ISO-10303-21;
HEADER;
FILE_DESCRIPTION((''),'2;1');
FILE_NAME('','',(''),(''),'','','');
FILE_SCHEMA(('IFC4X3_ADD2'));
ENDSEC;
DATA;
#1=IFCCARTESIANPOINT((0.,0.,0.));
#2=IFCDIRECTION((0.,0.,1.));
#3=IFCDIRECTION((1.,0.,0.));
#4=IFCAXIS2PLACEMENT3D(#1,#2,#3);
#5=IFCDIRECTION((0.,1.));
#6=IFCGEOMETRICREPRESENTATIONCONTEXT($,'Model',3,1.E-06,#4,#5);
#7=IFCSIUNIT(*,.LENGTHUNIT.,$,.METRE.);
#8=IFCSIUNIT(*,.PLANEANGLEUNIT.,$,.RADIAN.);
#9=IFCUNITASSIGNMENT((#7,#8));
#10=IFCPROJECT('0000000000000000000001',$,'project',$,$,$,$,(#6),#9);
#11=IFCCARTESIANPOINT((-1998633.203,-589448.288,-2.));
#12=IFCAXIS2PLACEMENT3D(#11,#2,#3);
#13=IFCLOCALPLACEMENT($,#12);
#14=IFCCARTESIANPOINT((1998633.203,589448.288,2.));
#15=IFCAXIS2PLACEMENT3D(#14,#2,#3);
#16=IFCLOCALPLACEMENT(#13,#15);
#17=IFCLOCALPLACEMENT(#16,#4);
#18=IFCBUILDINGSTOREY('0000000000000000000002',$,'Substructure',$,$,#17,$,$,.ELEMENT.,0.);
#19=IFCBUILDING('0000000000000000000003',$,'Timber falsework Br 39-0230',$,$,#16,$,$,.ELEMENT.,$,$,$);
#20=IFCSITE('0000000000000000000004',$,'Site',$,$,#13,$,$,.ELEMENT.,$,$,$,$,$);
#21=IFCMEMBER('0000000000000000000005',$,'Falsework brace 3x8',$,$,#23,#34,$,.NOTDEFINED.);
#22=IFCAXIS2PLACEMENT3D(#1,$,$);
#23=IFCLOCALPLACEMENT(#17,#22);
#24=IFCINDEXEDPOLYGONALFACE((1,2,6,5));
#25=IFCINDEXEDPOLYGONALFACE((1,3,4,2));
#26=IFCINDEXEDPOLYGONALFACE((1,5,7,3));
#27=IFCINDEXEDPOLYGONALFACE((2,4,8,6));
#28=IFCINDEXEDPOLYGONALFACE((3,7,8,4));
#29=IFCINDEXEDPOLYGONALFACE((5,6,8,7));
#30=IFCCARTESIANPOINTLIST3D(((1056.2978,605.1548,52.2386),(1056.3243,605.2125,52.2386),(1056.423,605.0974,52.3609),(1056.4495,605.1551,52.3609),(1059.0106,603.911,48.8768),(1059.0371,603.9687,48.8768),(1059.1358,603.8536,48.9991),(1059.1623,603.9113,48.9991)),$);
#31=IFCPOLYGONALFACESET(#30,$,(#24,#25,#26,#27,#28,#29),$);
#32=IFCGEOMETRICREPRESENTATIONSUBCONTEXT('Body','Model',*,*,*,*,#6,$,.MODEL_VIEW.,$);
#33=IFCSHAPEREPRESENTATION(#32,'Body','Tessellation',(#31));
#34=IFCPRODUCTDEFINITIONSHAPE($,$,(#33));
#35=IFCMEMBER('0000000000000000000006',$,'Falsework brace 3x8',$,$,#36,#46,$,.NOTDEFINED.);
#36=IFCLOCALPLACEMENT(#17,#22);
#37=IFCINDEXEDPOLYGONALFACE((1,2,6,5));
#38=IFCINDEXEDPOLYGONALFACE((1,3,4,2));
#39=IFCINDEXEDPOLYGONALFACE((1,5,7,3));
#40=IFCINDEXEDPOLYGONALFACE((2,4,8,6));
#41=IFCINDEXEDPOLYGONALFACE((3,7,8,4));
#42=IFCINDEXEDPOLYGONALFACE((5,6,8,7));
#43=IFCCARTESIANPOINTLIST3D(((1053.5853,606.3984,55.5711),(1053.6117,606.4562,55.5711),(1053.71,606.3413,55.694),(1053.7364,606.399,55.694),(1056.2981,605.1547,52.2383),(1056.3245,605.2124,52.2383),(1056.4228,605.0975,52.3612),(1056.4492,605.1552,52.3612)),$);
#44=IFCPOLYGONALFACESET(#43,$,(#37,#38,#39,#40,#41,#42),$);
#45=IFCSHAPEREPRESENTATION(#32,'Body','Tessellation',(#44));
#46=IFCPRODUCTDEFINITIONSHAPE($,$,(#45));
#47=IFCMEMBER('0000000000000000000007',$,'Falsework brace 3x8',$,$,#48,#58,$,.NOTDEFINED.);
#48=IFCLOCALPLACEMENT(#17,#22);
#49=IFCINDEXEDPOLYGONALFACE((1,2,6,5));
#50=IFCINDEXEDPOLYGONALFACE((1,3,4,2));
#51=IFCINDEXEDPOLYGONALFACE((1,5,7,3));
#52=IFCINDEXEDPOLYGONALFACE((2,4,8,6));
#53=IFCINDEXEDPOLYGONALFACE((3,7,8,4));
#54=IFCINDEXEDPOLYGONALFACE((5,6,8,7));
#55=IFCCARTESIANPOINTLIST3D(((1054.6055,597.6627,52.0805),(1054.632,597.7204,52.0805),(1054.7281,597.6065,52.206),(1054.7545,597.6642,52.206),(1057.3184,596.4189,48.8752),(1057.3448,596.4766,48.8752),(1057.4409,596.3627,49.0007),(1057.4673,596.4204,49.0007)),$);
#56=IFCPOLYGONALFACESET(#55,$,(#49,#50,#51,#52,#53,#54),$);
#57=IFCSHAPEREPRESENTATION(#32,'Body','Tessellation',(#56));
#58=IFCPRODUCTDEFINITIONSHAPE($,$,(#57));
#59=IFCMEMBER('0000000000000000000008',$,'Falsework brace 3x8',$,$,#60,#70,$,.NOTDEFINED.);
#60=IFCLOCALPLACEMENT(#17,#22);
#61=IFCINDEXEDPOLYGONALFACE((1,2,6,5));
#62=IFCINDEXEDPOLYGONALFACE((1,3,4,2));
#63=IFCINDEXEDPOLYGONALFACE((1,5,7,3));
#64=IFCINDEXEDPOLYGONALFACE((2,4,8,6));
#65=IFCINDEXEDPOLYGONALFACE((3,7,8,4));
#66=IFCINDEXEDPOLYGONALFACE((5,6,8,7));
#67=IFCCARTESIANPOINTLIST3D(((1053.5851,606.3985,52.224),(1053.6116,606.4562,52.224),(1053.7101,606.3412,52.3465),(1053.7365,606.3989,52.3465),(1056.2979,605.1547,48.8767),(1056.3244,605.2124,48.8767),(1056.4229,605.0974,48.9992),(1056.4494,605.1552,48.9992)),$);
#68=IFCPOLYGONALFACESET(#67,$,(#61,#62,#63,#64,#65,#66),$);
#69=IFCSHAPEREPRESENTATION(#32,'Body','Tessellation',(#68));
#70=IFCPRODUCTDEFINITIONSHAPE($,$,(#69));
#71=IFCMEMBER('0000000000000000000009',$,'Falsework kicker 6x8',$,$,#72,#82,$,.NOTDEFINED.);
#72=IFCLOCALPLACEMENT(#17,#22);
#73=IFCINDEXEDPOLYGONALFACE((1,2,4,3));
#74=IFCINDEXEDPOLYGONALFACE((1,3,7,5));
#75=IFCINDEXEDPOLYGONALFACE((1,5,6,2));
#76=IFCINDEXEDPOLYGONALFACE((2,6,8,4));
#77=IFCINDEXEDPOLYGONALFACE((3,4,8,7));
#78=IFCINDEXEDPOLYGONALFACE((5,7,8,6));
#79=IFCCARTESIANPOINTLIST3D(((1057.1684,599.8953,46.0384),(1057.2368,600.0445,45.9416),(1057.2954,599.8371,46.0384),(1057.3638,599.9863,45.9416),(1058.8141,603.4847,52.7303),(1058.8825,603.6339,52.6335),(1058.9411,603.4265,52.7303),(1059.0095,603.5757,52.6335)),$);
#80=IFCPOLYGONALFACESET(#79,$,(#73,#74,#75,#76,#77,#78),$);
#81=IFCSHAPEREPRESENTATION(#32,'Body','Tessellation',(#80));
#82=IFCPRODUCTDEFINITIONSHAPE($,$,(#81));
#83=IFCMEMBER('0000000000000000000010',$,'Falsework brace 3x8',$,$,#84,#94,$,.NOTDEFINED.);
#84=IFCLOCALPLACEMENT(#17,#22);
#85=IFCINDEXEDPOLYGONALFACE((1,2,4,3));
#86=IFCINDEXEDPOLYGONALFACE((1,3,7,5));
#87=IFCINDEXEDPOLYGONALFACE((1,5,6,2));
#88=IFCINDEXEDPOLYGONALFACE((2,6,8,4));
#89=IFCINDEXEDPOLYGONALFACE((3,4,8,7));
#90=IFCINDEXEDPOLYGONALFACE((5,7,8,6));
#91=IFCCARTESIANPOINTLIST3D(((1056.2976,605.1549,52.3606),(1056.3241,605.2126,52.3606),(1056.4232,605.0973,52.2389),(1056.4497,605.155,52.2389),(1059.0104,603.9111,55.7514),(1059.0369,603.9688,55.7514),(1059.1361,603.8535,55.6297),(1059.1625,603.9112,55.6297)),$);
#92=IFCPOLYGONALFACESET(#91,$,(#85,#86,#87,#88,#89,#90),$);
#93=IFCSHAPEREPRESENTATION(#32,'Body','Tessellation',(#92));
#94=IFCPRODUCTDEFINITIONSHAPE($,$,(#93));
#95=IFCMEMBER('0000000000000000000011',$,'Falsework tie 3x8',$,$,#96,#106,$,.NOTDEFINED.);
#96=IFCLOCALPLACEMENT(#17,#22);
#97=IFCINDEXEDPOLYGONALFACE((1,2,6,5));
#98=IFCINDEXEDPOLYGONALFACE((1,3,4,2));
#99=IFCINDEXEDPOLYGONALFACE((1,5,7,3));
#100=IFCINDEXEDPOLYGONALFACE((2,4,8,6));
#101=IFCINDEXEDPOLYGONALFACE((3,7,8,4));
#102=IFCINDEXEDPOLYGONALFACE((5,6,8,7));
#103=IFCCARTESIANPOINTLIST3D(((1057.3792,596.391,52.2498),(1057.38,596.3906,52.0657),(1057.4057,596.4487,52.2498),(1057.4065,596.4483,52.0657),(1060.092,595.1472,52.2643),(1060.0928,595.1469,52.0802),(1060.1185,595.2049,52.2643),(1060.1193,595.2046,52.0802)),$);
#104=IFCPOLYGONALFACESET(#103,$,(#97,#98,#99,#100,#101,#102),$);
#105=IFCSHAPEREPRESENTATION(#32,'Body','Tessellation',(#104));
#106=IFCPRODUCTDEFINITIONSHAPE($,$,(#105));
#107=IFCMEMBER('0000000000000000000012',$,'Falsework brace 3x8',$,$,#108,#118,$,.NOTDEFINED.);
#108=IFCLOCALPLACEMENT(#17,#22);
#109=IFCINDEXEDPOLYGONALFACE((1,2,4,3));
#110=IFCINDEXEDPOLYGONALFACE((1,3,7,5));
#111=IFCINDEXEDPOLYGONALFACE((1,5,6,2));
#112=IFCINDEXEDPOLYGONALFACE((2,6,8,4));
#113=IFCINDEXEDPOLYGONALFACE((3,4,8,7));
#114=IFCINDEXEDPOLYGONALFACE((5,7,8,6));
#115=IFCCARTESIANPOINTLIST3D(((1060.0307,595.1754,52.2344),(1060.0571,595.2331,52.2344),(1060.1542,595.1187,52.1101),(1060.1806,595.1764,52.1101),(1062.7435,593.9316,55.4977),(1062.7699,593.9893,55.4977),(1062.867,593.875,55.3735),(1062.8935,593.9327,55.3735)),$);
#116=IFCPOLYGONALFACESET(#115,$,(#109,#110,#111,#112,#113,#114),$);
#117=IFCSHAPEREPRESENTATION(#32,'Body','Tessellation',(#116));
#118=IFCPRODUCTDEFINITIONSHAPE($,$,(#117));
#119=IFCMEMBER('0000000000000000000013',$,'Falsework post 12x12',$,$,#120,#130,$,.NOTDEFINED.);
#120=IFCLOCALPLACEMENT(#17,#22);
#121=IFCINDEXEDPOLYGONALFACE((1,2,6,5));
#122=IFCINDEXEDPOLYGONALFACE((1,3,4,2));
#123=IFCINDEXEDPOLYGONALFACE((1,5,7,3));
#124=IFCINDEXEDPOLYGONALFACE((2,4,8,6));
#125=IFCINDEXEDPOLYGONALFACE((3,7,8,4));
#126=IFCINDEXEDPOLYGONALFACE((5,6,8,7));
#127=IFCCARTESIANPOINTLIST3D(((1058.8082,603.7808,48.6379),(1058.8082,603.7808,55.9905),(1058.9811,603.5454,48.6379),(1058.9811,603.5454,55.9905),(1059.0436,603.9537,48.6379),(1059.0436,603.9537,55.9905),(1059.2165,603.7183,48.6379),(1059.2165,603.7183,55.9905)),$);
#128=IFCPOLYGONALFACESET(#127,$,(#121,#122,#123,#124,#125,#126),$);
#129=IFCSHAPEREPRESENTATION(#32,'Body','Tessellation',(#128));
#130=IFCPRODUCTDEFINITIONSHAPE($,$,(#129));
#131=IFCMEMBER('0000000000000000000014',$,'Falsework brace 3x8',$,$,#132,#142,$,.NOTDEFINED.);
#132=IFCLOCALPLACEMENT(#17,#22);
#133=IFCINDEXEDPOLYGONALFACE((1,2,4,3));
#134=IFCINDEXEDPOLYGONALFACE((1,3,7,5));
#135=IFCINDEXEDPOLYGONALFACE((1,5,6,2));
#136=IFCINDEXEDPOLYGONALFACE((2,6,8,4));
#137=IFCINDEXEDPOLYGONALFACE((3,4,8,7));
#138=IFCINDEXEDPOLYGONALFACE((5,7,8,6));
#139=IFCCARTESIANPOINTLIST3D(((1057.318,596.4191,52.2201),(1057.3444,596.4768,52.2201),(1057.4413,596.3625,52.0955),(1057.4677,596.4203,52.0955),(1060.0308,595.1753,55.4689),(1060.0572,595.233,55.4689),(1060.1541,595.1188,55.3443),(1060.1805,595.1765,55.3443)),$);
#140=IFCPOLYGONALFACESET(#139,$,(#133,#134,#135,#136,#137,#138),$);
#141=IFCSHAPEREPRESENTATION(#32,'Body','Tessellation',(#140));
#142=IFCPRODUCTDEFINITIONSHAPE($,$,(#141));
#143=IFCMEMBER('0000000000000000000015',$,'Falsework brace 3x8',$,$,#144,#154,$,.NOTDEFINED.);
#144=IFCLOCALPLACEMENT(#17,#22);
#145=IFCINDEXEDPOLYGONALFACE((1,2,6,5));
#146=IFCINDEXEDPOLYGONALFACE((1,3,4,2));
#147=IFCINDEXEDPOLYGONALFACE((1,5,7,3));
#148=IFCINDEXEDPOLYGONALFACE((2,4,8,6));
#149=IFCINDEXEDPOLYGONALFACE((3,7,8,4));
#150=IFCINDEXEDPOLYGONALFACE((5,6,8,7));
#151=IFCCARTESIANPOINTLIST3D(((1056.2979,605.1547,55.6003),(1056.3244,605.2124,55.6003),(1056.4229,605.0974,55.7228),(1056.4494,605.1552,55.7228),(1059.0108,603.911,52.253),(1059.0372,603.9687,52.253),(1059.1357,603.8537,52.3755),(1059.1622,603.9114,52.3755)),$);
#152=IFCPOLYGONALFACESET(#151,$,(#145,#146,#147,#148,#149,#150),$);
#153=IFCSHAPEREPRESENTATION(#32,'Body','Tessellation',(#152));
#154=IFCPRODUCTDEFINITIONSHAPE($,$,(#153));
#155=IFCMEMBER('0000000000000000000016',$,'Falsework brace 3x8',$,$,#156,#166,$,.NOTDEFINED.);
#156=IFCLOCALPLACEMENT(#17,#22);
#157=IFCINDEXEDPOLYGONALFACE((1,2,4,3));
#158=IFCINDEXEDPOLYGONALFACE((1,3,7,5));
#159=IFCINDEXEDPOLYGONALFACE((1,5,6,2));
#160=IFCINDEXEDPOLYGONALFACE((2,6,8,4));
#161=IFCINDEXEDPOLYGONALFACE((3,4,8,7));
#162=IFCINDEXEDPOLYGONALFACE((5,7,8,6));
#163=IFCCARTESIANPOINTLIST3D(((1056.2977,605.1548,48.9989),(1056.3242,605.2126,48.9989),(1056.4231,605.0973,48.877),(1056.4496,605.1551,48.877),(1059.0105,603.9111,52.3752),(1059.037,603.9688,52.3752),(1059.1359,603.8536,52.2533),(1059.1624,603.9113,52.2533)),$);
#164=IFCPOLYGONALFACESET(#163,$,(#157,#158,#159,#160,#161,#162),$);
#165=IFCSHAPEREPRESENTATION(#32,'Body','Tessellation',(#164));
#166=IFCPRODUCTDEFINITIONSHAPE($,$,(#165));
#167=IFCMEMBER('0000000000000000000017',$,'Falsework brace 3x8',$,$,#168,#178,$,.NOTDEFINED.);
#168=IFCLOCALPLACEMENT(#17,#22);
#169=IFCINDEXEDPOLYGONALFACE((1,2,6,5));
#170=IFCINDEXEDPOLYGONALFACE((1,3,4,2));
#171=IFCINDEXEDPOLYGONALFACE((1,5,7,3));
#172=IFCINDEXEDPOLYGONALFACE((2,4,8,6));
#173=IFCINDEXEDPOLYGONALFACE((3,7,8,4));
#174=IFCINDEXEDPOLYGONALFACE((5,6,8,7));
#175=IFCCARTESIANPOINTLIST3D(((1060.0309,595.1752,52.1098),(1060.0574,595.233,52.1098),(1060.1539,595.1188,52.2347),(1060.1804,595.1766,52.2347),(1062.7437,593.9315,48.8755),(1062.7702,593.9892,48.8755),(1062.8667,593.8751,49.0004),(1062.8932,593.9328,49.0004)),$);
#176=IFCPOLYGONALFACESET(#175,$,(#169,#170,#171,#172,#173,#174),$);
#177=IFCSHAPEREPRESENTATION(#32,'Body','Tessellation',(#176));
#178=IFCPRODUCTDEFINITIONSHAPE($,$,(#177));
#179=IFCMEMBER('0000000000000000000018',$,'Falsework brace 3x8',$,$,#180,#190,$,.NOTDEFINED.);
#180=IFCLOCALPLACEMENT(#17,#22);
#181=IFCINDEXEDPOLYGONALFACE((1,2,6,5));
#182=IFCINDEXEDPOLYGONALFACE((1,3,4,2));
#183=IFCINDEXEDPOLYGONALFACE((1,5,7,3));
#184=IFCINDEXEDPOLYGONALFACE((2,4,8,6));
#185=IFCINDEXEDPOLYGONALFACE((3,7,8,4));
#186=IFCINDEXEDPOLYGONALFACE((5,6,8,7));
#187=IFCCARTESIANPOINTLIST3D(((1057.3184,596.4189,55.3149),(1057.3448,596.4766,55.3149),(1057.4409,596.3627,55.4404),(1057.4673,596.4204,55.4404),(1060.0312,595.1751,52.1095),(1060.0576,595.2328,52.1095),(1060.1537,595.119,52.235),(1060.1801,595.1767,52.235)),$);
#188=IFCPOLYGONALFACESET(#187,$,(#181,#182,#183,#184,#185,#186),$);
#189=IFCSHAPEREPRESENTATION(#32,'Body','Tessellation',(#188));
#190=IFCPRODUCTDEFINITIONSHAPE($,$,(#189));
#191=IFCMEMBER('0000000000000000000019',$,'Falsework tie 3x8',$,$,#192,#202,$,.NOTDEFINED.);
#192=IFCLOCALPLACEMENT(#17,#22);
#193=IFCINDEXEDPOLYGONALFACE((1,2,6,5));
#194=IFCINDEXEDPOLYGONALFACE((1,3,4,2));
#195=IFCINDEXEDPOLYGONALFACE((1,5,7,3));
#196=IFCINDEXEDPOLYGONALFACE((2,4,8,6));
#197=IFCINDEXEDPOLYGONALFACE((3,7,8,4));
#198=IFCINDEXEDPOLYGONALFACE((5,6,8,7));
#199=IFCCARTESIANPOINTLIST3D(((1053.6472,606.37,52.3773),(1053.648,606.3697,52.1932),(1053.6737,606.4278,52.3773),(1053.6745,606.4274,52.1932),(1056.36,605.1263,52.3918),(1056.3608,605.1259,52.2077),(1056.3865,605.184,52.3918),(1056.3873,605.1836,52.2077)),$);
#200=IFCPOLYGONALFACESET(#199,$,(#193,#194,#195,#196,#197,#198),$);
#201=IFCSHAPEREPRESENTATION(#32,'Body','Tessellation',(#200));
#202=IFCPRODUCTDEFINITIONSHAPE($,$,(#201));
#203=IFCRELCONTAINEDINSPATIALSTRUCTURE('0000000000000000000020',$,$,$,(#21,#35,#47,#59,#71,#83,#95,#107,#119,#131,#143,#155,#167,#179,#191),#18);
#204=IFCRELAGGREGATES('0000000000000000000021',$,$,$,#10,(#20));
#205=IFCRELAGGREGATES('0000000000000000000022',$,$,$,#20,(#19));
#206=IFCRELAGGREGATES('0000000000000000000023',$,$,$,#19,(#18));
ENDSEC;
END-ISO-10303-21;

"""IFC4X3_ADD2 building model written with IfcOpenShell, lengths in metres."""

from ifc_helpers import new_model, si_unit, direction, frame, origin, origin_with_axes, origin_2d, place, context, subcontext, project, spatial, rectangle, extrude, element, save


model = new_model("IFC4X3_ADD2")

# Units and contexts
model_context = context("Model", 3, precision=1e-06, world=origin_with_axes(), true_north=direction((0.0, 1.0)))
body_context = subcontext(model_context, "Body", "Model", "MODEL_VIEW")
ifc_project = project(units=[si_unit("LENGTHUNIT", "METRE"), si_unit("PLANEANGLEUNIT", "RADIAN")], contexts=[model_context])

# Site, building, storey
site_placement = place(None, frame((-1998633.203, -589448.288, -2.0), z_axis=(0.0, 0.0, 1.0), x_axis=(1.0, 0.0, 0.0)))
site = spatial("IfcSite", under=ifc_project, at=site_placement, Name="Site", CompositionType="ELEMENT")
building_placement = place(site_placement, frame((1998633.203, 589448.288, 2.0), z_axis=(0.0, 0.0, 1.0), x_axis=(1.0, 0.0, 0.0)))
building = spatial("IfcBuilding", under=site, at=building_placement, Name="Timber falsework Br 39-0230", CompositionType="ELEMENT")
storey_placement = place(building_placement, origin_with_axes())
storey = spatial("IfcBuildingStorey", under=building, at=storey_placement, Name="Substructure", CompositionType="ELEMENT", Elevation=0.0)

# Members
member_1_placement = place(storey_placement, frame((1056.3737, 605.1549, 52.2997), z_axis=(0.603472, -0.27668, -0.747843), x_axis=(0.416765, 0.909014, 0.0)))
element("IfcMember", 1, at=member_1_placement, inside=storey, Name="Falsework brace 3x8", PredefinedType="NOTDEFINED", context=body_context, shape_type="SweptSolid", body=[
    extrude(rectangle(XDim=0.0635, YDim=0.1841, at=origin_2d()), origin(), (0.0, 0.0, 1.0), 4.4953),
])
member_2_placement = place(storey_placement, frame((1053.6608, 606.3987, 55.6325), z_axis=(0.606392, -0.278019, -0.744979), x_axis=(0.416765, 0.909014, 0.0)))
element("IfcMember", 2, at=member_2_placement, inside=storey, Name="Falsework brace 3x8", PredefinedType="NOTDEFINED", context=body_context, shape_type="SweptSolid", body=[
    extrude(rectangle(XDim=0.0635, YDim=0.1841, at=origin_2d()), origin(), (0.0, 0.0, 1.0), 4.4737),
])
member_3_placement = place(storey_placement, frame((1054.68, 597.6634, 52.1433), z_axis=(0.619426, -0.283995, -0.731887), x_axis=(0.416765, 0.909014, 0.0)))
element("IfcMember", 3, at=member_3_placement, inside=storey, Name="Falsework brace 3x8", PredefinedType="NOTDEFINED", context=body_context, shape_type="SweptSolid", body=[
    extrude(rectangle(XDim=0.0635, YDim=0.1841, at=origin_2d()), origin(), (0.0, 0.0, 1.0), 4.3795),
])
member_4_placement = place(storey_placement, frame((1053.6608, 606.3987, 52.2852), z_axis=(0.60493, -0.277349, -0.746416), x_axis=(0.416765, 0.909014, 0.0)))
element("IfcMember", 4, at=member_4_placement, inside=storey, Name="Falsework brace 3x8", PredefinedType="NOTDEFINED", context=body_context, shape_type="SweptSolid", body=[
    extrude(rectangle(XDim=0.0635, YDim=0.1841, at=origin_2d()), origin(), (0.0, 0.0, 1.0), 4.4845),
])
member_5_placement = place(storey_placement, frame((1058.9118, 603.5302, 52.6819), z_axis=(-0.211798, -0.461956, -0.861242), x_axis=(0.909014, -0.416765, 0.0)))
element("IfcMember", 5, at=member_5_placement, inside=storey, Name="Falsework kicker 6x8", PredefinedType="NOTDEFINED", context=body_context, shape_type="SweptSolid", body=[
    extrude(rectangle(XDim=0.1397, YDim=0.1905, at=origin_2d()), origin(), (0.0, 0.0, 1.0), 7.77),
])
member_6_placement = place(storey_placement, frame((1056.3737, 605.1549, 52.2997), z_axis=(0.600569, -0.275349, 0.750666), x_axis=(0.416765, 0.909014, 0.0)))
element("IfcMember", 6, at=member_6_placement, inside=storey, Name="Falsework brace 3x8", PredefinedType="NOTDEFINED", context=body_context, shape_type="SweptSolid", body=[
    extrude(rectangle(XDim=0.0635, YDim=0.1841, at=origin_2d()), origin(), (0.0, 0.0, 1.0), 4.5171),
])
member_7_placement = place(storey_placement, frame((1057.3928, 596.4197, 52.1578), z_axis=(0.909003, -0.41676, 0.004859), x_axis=(0.416765, 0.909014, 0.0)))
element("IfcMember", 7, at=member_7_placement, inside=storey, Name="Falsework tie 3x8", PredefinedType="NOTDEFINED", context=body_context, shape_type="SweptSolid", body=[
    extrude(rectangle(XDim=0.0635, YDim=0.1841, at=origin_2d()), origin(), (0.0, 0.0, 1.0), 2.9844),
])
member_8_placement = place(storey_placement, frame((1060.1057, 595.1759, 52.1723), z_axis=(0.613455, -0.281257, 0.737948), x_axis=(0.416765, 0.909014, 0.0)))
element("IfcMember", 8, at=member_8_placement, inside=storey, Name="Falsework brace 3x8", PredefinedType="NOTDEFINED", context=body_context, shape_type="SweptSolid", body=[
    extrude(rectangle(XDim=0.0635, YDim=0.1841, at=origin_2d()), origin(), (0.0, 0.0, 1.0), 4.4222),
])
member_9_placement = place(storey_placement, frame((1059.0124, 603.7496, 48.6379), z_axis=(0.0, 0.0, 1.0), x_axis=(-0.805928, -0.592013, 0.0)))
element("IfcMember", 9, at=member_9_placement, inside=storey, Name="Falsework post 12x12", PredefinedType="NOTDEFINED", context=body_context, shape_type="SweptSolid", body=[
    extrude(rectangle(XDim=0.2921, YDim=0.2921, at=origin_2d()), origin(), (0.0, 0.0, 1.0), 7.3526),
])
member_10_placement = place(storey_placement, frame((1057.3928, 596.4197, 52.1578), z_axis=(0.614942, -0.281939, 0.736449), x_axis=(0.416765, 0.909014, 0.0)))
element("IfcMember", 10, at=member_10_placement, inside=storey, Name="Falsework brace 3x8", PredefinedType="NOTDEFINED", context=body_context, shape_type="SweptSolid", body=[
    extrude(rectangle(XDim=0.0635, YDim=0.1841, at=origin_2d()), origin(), (0.0, 0.0, 1.0), 4.4115),
])
member_11_placement = place(storey_placement, frame((1056.3737, 605.1549, 55.6615), z_axis=(0.60493, -0.277349, -0.746416), x_axis=(0.416765, 0.909014, 0.0)))
element("IfcMember", 11, at=member_11_placement, inside=storey, Name="Falsework brace 3x8", PredefinedType="NOTDEFINED", context=body_context, shape_type="SweptSolid", body=[
    extrude(rectangle(XDim=0.0635, YDim=0.1841, at=origin_2d()), origin(), (0.0, 0.0, 1.0), 4.4845),
])
member_12_placement = place(storey_placement, frame((1056.3737, 605.1549, 48.9379), z_axis=(0.602019, -0.276014, 0.74926), x_axis=(0.416765, 0.909014, 0.0)))
element("IfcMember", 12, at=member_12_placement, inside=storey, Name="Falsework brace 3x8", PredefinedType="NOTDEFINED", context=body_context, shape_type="SweptSolid", body=[
    extrude(rectangle(XDim=0.0635, YDim=0.1841, at=origin_2d()), origin(), (0.0, 0.0, 1.0), 4.5062),
])
member_13_placement = place(storey_placement, frame((1060.1057, 595.1759, 52.1723), z_axis=(0.616432, -0.282622, -0.734939), x_axis=(0.416765, 0.909014, 0.0)))
element("IfcMember", 13, at=member_13_placement, inside=storey, Name="Falsework brace 3x8", PredefinedType="NOTDEFINED", context=body_context, shape_type="SweptSolid", body=[
    extrude(rectangle(XDim=0.0635, YDim=0.1841, at=origin_2d()), origin(), (0.0, 0.0, 1.0), 4.4008),
])
member_14_placement = place(storey_placement, frame((1057.3928, 596.4197, 55.3776), z_axis=(0.619426, -0.283995, -0.731887), x_axis=(0.416765, 0.909014, 0.0)))
element("IfcMember", 14, at=member_14_placement, inside=storey, Name="Falsework brace 3x8", PredefinedType="NOTDEFINED", context=body_context, shape_type="SweptSolid", body=[
    extrude(rectangle(XDim=0.0635, YDim=0.1841, at=origin_2d()), origin(), (0.0, 0.0, 1.0), 4.3795),
])
member_15_placement = place(storey_placement, frame((1053.6608, 606.3987, 52.2852), z_axis=(0.909003, -0.41676, 0.004859), x_axis=(0.416765, 0.909014, 0.0)))
element("IfcMember", 15, at=member_15_placement, inside=storey, Name="Falsework tie 3x8", PredefinedType="NOTDEFINED", context=body_context, shape_type="SweptSolid", body=[
    extrude(rectangle(XDim=0.0635, YDim=0.1841, at=origin_2d()), origin(), (0.0, 0.0, 1.0), 2.9844),
])

save(model, "model.ifc")
